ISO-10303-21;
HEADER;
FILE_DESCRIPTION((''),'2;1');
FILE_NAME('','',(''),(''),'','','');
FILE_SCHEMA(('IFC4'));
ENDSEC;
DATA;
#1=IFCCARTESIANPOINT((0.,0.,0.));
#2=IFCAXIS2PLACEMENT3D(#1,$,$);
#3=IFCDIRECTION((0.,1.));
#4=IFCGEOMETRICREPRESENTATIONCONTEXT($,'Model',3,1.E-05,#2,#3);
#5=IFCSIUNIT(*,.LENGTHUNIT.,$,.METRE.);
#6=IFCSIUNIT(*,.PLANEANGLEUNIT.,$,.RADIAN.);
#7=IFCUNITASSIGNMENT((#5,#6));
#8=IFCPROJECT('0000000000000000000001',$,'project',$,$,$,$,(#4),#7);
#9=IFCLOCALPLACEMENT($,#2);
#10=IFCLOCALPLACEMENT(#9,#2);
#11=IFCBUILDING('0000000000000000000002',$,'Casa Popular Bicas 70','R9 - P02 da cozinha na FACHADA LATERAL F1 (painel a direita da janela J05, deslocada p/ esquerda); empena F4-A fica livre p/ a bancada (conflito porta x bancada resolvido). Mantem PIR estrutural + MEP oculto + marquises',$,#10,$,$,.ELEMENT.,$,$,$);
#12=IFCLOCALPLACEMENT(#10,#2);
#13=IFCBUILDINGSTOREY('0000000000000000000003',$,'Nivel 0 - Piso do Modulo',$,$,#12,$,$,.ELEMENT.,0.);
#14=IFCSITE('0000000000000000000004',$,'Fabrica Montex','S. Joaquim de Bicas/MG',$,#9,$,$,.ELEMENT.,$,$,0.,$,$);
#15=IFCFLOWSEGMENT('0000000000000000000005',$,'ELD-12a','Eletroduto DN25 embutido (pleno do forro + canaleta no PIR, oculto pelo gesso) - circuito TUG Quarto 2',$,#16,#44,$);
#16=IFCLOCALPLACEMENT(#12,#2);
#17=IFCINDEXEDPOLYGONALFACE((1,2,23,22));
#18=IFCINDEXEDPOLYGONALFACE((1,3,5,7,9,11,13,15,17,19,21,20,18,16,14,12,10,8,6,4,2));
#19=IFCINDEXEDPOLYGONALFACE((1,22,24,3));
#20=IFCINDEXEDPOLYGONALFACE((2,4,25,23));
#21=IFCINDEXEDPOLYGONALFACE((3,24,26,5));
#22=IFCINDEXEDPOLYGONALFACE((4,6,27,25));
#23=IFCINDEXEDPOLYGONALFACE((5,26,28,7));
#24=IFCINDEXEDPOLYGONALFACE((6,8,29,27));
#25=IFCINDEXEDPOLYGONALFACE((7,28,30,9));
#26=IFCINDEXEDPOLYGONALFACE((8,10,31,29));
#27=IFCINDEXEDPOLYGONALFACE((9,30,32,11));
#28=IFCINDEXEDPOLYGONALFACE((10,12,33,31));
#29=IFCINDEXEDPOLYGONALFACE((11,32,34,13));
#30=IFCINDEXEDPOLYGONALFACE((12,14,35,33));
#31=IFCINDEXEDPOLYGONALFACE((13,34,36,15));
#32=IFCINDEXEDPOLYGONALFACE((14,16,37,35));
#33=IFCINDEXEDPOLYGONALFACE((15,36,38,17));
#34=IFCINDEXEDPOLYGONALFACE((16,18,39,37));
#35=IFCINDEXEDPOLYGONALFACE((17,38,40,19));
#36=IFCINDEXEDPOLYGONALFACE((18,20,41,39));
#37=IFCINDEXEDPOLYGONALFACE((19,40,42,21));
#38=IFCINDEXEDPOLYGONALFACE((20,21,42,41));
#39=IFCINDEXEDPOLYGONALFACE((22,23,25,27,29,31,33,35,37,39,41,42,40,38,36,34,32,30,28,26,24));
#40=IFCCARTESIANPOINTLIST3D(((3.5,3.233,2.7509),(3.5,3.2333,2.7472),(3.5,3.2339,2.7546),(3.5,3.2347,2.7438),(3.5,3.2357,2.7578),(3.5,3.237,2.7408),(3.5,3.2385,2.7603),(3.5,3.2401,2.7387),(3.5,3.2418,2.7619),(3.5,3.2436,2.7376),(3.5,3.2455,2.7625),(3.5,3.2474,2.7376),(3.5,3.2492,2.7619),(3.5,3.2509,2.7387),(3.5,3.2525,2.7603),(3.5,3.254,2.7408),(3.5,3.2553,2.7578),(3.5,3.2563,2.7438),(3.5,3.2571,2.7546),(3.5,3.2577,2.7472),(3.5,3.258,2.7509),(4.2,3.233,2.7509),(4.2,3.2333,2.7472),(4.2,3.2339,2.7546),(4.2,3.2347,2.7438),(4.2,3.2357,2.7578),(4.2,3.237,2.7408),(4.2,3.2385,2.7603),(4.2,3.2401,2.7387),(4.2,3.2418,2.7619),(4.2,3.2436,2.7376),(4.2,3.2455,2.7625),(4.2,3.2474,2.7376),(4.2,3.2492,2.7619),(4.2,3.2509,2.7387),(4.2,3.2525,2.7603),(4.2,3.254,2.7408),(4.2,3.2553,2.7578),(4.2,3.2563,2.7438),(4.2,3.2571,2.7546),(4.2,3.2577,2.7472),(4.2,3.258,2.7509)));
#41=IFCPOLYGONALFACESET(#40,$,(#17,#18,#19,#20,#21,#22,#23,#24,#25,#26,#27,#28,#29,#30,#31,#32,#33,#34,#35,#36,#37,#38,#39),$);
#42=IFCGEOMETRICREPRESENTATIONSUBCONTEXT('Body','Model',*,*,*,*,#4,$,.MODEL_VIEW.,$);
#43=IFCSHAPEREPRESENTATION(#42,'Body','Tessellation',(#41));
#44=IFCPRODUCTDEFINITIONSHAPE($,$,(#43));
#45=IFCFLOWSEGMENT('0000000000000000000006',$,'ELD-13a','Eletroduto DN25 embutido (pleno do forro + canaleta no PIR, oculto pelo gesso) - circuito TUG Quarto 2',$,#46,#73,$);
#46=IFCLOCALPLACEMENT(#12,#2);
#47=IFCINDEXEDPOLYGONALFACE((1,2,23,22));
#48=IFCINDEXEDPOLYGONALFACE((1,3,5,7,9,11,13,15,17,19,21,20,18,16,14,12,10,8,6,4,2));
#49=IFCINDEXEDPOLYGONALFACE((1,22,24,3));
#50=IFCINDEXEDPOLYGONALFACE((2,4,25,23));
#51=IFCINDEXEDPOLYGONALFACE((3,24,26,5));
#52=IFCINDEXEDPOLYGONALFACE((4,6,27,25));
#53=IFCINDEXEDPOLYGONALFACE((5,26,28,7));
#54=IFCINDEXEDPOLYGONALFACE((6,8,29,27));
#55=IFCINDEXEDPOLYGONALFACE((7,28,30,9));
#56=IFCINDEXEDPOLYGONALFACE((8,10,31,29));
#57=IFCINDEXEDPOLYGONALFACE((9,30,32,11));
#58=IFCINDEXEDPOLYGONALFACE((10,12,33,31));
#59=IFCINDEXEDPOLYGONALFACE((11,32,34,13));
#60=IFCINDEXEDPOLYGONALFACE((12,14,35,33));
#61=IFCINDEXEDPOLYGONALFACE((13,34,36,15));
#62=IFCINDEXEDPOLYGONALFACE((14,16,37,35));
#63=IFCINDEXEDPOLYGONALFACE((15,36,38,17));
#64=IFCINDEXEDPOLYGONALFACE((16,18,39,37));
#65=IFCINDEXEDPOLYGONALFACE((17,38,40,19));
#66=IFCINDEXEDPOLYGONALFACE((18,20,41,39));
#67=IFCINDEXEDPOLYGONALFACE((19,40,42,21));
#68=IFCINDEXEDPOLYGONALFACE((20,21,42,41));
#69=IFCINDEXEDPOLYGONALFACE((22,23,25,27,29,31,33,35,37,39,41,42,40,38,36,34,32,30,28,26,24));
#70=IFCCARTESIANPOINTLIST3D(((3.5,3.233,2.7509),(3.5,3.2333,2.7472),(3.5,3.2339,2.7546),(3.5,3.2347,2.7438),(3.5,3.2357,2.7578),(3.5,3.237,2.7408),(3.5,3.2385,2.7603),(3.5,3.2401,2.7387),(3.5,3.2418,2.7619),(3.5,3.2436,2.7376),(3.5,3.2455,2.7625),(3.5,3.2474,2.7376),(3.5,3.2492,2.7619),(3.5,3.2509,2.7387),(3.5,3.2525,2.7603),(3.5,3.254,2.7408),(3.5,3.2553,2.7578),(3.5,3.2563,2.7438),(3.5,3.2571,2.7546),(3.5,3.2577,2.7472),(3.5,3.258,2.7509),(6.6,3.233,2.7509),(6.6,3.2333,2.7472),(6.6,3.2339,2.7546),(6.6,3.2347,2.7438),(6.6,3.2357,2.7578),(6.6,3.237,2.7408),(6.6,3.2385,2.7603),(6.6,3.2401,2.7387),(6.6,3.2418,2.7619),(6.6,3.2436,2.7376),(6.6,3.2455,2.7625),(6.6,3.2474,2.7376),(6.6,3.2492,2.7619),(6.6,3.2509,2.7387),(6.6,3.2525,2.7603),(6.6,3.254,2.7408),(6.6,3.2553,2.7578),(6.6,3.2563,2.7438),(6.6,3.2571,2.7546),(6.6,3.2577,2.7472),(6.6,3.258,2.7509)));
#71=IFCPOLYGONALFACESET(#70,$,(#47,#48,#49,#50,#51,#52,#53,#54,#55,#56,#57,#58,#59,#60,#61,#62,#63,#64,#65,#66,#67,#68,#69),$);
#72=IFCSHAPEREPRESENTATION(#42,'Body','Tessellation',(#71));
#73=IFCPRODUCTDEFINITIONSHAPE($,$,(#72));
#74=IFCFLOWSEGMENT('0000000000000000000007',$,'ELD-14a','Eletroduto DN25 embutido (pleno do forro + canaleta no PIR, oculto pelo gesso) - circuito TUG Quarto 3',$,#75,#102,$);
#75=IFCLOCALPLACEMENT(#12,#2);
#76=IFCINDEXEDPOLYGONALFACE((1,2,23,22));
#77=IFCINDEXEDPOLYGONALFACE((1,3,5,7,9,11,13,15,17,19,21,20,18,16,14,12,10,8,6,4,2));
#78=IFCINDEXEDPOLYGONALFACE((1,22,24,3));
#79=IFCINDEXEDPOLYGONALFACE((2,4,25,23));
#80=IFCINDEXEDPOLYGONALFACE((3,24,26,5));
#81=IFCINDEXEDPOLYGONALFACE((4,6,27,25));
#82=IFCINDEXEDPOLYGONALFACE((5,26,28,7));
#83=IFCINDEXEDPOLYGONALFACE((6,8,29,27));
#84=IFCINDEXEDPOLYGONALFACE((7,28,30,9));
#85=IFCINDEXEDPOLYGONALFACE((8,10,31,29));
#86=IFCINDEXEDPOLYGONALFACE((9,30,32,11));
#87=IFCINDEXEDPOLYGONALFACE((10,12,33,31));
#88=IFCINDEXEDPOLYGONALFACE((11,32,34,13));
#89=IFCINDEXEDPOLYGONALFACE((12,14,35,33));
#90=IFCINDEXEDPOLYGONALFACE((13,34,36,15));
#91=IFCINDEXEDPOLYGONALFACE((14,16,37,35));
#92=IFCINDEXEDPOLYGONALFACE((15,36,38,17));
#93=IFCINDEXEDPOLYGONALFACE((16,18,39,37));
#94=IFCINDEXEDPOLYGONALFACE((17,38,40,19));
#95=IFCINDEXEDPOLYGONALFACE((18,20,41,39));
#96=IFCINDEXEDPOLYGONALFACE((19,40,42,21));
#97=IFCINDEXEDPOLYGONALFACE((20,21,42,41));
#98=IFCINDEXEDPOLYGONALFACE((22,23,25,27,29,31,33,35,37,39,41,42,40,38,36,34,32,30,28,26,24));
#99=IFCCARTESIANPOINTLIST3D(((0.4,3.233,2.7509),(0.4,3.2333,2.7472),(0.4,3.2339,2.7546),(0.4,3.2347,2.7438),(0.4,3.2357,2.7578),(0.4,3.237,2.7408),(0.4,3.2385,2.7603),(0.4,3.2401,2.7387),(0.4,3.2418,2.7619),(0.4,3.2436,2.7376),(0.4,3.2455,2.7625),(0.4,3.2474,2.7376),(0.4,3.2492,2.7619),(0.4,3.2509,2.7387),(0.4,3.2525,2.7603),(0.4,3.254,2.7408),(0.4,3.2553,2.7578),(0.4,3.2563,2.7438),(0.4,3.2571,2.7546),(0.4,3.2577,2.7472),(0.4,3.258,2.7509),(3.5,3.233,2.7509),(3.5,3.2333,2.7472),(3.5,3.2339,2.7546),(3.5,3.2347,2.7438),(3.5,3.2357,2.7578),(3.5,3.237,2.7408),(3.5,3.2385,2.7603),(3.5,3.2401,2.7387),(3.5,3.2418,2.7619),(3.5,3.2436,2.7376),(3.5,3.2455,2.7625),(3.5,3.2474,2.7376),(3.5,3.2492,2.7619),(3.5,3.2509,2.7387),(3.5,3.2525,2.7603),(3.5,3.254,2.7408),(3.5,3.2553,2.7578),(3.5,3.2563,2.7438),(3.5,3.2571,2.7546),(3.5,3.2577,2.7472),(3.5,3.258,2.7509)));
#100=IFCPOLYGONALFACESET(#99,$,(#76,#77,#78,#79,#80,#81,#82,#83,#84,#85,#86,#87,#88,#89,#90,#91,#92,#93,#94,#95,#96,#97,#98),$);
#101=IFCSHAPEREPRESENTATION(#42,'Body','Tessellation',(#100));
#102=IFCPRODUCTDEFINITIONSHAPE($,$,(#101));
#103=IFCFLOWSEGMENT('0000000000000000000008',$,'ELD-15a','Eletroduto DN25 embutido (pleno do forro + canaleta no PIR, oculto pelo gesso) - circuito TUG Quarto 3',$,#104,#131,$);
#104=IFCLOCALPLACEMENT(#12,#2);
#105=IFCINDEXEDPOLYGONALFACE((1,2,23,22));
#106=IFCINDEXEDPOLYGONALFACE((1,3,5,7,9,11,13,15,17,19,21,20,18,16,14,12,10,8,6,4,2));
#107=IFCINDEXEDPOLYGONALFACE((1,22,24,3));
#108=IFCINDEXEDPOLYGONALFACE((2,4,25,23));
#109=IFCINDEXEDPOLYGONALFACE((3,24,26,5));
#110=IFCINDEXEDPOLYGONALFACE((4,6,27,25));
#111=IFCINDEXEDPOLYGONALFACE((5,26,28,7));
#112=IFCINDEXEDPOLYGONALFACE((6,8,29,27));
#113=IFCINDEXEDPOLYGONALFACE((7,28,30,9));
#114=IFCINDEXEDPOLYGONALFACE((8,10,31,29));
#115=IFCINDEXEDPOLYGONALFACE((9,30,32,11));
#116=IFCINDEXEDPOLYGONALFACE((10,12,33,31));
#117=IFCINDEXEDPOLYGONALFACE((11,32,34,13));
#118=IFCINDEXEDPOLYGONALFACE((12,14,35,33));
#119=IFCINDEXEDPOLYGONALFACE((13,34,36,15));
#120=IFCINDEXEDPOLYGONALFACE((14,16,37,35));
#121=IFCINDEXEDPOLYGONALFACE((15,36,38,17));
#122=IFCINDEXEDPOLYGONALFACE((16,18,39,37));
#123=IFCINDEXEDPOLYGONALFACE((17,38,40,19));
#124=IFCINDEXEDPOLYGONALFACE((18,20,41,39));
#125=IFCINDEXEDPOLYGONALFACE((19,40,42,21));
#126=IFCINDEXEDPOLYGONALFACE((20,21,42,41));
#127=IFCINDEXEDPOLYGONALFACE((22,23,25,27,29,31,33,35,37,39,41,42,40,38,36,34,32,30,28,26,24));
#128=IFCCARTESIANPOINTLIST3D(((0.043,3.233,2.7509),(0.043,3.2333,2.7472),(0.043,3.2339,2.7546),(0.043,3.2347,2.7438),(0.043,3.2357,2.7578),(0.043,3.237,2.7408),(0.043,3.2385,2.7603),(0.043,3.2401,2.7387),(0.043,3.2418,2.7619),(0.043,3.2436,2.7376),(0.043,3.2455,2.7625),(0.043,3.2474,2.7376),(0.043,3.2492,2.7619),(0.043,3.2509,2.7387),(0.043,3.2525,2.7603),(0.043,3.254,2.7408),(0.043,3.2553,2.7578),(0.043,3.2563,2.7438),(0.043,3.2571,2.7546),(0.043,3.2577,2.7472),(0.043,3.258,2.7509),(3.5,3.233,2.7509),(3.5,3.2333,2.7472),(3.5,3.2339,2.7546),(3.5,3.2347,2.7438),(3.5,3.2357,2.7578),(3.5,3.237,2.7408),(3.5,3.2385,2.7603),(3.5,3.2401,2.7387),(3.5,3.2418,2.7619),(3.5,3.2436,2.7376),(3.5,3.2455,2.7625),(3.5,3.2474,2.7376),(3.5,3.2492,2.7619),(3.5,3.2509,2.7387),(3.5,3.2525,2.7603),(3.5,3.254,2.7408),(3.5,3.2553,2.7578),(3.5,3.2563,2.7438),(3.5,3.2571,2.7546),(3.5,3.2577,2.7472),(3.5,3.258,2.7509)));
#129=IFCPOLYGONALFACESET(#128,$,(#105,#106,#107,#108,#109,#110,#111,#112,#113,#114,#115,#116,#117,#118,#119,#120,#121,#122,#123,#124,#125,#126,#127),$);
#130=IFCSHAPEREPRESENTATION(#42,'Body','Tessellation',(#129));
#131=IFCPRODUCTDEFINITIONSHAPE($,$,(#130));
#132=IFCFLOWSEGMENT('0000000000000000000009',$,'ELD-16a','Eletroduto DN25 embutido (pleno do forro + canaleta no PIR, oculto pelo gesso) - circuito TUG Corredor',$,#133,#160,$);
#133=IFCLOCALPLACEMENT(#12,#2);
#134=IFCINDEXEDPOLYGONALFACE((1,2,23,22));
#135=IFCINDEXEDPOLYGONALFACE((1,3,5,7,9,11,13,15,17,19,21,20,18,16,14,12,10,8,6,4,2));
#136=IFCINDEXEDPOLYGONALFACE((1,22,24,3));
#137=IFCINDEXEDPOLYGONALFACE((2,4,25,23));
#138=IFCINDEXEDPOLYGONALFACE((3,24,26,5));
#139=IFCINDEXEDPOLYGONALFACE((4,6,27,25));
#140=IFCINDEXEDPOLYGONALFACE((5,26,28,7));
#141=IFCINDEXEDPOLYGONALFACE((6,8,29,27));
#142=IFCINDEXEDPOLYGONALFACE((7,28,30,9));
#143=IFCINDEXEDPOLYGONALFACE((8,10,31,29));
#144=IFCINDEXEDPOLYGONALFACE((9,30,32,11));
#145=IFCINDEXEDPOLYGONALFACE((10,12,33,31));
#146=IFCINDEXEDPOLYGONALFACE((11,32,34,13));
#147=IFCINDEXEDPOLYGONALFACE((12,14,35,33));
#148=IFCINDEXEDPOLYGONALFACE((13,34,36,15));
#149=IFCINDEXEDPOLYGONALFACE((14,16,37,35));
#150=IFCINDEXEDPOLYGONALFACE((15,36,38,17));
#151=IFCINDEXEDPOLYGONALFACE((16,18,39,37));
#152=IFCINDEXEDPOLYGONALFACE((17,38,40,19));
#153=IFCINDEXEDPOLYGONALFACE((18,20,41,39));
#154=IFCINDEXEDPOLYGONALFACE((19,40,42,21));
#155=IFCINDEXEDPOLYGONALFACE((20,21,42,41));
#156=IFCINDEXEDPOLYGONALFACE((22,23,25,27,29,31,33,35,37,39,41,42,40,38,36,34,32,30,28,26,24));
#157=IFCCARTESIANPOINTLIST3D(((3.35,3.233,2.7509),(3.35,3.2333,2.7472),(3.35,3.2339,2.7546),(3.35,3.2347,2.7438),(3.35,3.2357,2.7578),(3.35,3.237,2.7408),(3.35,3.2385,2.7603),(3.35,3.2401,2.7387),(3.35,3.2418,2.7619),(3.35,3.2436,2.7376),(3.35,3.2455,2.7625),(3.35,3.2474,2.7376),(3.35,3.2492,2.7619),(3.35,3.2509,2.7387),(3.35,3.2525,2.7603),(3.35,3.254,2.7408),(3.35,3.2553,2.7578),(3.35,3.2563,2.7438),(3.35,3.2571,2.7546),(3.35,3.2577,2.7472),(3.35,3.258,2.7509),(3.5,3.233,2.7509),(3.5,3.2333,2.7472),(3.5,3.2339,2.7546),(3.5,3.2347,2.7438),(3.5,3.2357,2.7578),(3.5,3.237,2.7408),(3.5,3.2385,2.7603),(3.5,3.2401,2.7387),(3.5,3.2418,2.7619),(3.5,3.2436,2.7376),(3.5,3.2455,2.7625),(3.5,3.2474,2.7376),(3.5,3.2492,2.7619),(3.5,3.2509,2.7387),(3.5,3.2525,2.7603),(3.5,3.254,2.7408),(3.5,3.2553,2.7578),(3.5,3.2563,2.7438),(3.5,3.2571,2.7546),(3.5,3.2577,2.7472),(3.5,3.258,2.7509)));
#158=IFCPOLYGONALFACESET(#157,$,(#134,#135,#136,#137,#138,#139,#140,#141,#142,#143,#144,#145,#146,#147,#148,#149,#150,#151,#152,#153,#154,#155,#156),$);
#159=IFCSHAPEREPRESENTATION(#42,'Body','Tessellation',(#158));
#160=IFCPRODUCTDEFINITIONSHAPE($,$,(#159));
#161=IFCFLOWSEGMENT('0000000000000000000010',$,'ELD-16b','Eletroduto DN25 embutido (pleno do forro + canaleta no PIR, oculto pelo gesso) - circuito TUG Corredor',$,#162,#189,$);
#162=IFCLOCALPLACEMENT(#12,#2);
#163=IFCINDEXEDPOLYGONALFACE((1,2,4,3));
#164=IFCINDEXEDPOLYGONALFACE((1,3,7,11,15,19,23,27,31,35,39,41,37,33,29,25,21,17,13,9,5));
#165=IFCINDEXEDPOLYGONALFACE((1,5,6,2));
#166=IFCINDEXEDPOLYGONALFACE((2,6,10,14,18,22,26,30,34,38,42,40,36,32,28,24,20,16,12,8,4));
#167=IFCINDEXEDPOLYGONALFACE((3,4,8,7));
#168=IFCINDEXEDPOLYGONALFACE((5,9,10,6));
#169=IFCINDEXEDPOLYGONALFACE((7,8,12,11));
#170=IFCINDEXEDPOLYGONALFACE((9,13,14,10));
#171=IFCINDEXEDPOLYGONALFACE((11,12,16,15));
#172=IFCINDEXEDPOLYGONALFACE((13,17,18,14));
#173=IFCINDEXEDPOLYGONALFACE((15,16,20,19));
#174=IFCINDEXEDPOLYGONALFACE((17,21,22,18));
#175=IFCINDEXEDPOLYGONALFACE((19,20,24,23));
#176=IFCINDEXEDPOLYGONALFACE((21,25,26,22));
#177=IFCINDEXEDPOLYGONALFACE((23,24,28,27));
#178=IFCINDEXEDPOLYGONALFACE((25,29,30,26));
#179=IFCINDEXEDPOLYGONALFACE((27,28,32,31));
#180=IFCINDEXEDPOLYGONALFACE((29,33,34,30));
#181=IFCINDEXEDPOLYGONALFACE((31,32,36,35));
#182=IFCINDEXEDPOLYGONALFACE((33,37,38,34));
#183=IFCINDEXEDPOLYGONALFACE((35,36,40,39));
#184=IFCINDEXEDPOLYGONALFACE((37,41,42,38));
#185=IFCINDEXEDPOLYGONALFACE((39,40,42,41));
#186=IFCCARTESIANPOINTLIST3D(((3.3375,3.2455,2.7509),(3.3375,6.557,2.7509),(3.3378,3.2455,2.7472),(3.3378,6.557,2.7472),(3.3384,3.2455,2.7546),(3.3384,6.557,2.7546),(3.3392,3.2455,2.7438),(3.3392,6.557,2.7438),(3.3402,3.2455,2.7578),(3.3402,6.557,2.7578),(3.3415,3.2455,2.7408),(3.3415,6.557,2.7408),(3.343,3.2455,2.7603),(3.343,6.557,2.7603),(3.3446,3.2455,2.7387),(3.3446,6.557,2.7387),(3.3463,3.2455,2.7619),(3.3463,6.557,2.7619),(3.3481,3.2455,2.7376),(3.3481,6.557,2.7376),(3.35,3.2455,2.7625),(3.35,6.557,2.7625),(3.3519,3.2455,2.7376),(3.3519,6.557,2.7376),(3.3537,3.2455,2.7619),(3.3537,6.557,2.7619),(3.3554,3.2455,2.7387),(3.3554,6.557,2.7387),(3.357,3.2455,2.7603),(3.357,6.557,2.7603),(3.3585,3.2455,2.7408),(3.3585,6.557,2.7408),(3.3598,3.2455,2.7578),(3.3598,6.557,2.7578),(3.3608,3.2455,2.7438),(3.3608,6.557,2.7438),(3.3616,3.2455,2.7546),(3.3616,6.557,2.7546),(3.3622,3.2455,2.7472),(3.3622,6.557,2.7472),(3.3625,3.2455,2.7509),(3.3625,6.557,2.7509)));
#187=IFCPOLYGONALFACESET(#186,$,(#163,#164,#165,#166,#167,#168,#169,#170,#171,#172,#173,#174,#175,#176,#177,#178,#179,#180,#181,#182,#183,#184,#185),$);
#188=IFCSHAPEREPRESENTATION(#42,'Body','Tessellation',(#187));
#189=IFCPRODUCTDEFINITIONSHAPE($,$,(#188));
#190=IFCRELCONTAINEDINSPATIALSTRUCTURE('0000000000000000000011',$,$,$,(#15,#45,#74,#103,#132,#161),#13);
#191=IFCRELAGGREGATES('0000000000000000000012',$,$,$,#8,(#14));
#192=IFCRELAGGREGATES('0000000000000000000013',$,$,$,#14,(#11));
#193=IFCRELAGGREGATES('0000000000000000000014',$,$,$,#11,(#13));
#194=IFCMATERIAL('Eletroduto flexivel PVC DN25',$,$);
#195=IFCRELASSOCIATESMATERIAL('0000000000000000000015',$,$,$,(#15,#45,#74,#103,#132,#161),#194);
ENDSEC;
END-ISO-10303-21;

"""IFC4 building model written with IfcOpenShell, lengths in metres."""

from ifc_helpers import new_model, si_unit, direction, frame, origin, origin_2d, place, context, subcontext, project, spatial, circle, extrude, material, element, save


model = new_model("IFC4")

# Units and contexts
model_context = context("Model", 3, precision=1e-05, world=origin(), true_north=direction((0.0, 1.0)))
body_context = subcontext(model_context, "Body", "Model", "MODEL_VIEW")
ifc_project = project(units=[si_unit("LENGTHUNIT", "METRE"), si_unit("PLANEANGLEUNIT", "RADIAN")], contexts=[model_context])

# Site, building, storey
site_placement = place(None, origin())
site = spatial("IfcSite", under=ifc_project, at=site_placement, Name="Fabrica Montex", Description="S. Joaquim de Bicas/MG", CompositionType="ELEMENT", RefElevation=0.0)
building_placement = place(site_placement, origin())
building = spatial("IfcBuilding", under=site, at=building_placement, Name="Casa Popular Bicas 70", Description="R9 - P02 da cozinha na FACHADA LATERAL F1 (painel a direita da janela J05, deslocada p/ esquerda); empena F4-A fica livre p/ a bancada (conflito porta x bancada resolvido). Mantem PIR estrutural + MEP oculto + marquises", CompositionType="ELEMENT")
storey_placement = place(building_placement, origin())
storey = spatial("IfcBuildingStorey", under=building, at=storey_placement, Name="Nivel 0 - Piso do Modulo", CompositionType="ELEMENT", Elevation=0.0)

# Flow segments
ifc_material_1 = material(Name="Eletroduto flexivel PVC DN25")
flow_segment_1_placement = place(storey_placement, frame((3.5, 3.2455, 2.75), z_axis=(1.0, 0.0, 0.0), x_axis=(0.0, 0.0, 1.0)))
element("IfcFlowSegment", 1, at=flow_segment_1_placement, inside=storey, material=ifc_material_1, Name="ELD-12a", Description="Eletroduto DN25 embutido (pleno do forro + canaleta no PIR, oculto pelo gesso) - circuito TUG Quarto 2", context=body_context, shape_type="SweptSolid", body=[
    extrude(circle(Radius=0.0125, at=origin_2d()), origin(), (0.0, 0.0, 1.0), 0.7),
])
flow_segment_2_placement = place(storey_placement, frame((3.5, 3.2455, 2.75), z_axis=(1.0, 0.0, 0.0), x_axis=(0.0, 0.0, 1.0)))
element("IfcFlowSegment", 2, at=flow_segment_2_placement, inside=storey, material=ifc_material_1, Name="ELD-13a", Description="Eletroduto DN25 embutido (pleno do forro + canaleta no PIR, oculto pelo gesso) - circuito TUG Quarto 2", context=body_context, shape_type="SweptSolid", body=[
    extrude(circle(Radius=0.0125, at=origin_2d()), origin(), (0.0, 0.0, 1.0), 3.1),
])
flow_segment_3_placement = place(storey_placement, frame((3.5, 3.2455, 2.75), z_axis=(-1.0, 0.0, 0.0), x_axis=(0.0, 0.0, 1.0)))
element("IfcFlowSegment", 3, at=flow_segment_3_placement, inside=storey, material=ifc_material_1, Name="ELD-14a", Description="Eletroduto DN25 embutido (pleno do forro + canaleta no PIR, oculto pelo gesso) - circuito TUG Quarto 3", context=body_context, shape_type="SweptSolid", body=[
    extrude(circle(Radius=0.0125, at=origin_2d()), origin(), (0.0, 0.0, 1.0), 3.1),
])
flow_segment_4_placement = place(storey_placement, frame((3.5, 3.2455, 2.75), z_axis=(-1.0, 0.0, 0.0), x_axis=(0.0, 0.0, 1.0)))
element("IfcFlowSegment", 4, at=flow_segment_4_placement, inside=storey, material=ifc_material_1, Name="ELD-15a", Description="Eletroduto DN25 embutido (pleno do forro + canaleta no PIR, oculto pelo gesso) - circuito TUG Quarto 3", context=body_context, shape_type="SweptSolid", body=[
    extrude(circle(Radius=0.0125, at=origin_2d()), origin(), (0.0, 0.0, 1.0), 3.457),
])
flow_segment_5_placement = place(storey_placement, frame((3.5, 3.2455, 2.75), z_axis=(-1.0, 0.0, 0.0), x_axis=(0.0, 0.0, 1.0)))
element("IfcFlowSegment", 5, at=flow_segment_5_placement, inside=storey, material=ifc_material_1, Name="ELD-16a", Description="Eletroduto DN25 embutido (pleno do forro + canaleta no PIR, oculto pelo gesso) - circuito TUG Corredor", context=body_context, shape_type="SweptSolid", body=[
    extrude(circle(Radius=0.0125, at=origin_2d()), origin(), (0.0, 0.0, 1.0), 0.15),
])
flow_segment_6_placement = place(storey_placement, frame((3.35, 3.2455, 2.75), z_axis=(0.0, 1.0, 0.0), x_axis=(0.0, 0.0, 1.0)))
element("IfcFlowSegment", 6, at=flow_segment_6_placement, inside=storey, material=ifc_material_1, Name="ELD-16b", Description="Eletroduto DN25 embutido (pleno do forro + canaleta no PIR, oculto pelo gesso) - circuito TUG Corredor", context=body_context, shape_type="SweptSolid", body=[
    extrude(circle(Radius=0.0125, at=origin_2d()), origin(), (0.0, 0.0, 1.0), 3.3115),
])

save(model, "model.ifc")
